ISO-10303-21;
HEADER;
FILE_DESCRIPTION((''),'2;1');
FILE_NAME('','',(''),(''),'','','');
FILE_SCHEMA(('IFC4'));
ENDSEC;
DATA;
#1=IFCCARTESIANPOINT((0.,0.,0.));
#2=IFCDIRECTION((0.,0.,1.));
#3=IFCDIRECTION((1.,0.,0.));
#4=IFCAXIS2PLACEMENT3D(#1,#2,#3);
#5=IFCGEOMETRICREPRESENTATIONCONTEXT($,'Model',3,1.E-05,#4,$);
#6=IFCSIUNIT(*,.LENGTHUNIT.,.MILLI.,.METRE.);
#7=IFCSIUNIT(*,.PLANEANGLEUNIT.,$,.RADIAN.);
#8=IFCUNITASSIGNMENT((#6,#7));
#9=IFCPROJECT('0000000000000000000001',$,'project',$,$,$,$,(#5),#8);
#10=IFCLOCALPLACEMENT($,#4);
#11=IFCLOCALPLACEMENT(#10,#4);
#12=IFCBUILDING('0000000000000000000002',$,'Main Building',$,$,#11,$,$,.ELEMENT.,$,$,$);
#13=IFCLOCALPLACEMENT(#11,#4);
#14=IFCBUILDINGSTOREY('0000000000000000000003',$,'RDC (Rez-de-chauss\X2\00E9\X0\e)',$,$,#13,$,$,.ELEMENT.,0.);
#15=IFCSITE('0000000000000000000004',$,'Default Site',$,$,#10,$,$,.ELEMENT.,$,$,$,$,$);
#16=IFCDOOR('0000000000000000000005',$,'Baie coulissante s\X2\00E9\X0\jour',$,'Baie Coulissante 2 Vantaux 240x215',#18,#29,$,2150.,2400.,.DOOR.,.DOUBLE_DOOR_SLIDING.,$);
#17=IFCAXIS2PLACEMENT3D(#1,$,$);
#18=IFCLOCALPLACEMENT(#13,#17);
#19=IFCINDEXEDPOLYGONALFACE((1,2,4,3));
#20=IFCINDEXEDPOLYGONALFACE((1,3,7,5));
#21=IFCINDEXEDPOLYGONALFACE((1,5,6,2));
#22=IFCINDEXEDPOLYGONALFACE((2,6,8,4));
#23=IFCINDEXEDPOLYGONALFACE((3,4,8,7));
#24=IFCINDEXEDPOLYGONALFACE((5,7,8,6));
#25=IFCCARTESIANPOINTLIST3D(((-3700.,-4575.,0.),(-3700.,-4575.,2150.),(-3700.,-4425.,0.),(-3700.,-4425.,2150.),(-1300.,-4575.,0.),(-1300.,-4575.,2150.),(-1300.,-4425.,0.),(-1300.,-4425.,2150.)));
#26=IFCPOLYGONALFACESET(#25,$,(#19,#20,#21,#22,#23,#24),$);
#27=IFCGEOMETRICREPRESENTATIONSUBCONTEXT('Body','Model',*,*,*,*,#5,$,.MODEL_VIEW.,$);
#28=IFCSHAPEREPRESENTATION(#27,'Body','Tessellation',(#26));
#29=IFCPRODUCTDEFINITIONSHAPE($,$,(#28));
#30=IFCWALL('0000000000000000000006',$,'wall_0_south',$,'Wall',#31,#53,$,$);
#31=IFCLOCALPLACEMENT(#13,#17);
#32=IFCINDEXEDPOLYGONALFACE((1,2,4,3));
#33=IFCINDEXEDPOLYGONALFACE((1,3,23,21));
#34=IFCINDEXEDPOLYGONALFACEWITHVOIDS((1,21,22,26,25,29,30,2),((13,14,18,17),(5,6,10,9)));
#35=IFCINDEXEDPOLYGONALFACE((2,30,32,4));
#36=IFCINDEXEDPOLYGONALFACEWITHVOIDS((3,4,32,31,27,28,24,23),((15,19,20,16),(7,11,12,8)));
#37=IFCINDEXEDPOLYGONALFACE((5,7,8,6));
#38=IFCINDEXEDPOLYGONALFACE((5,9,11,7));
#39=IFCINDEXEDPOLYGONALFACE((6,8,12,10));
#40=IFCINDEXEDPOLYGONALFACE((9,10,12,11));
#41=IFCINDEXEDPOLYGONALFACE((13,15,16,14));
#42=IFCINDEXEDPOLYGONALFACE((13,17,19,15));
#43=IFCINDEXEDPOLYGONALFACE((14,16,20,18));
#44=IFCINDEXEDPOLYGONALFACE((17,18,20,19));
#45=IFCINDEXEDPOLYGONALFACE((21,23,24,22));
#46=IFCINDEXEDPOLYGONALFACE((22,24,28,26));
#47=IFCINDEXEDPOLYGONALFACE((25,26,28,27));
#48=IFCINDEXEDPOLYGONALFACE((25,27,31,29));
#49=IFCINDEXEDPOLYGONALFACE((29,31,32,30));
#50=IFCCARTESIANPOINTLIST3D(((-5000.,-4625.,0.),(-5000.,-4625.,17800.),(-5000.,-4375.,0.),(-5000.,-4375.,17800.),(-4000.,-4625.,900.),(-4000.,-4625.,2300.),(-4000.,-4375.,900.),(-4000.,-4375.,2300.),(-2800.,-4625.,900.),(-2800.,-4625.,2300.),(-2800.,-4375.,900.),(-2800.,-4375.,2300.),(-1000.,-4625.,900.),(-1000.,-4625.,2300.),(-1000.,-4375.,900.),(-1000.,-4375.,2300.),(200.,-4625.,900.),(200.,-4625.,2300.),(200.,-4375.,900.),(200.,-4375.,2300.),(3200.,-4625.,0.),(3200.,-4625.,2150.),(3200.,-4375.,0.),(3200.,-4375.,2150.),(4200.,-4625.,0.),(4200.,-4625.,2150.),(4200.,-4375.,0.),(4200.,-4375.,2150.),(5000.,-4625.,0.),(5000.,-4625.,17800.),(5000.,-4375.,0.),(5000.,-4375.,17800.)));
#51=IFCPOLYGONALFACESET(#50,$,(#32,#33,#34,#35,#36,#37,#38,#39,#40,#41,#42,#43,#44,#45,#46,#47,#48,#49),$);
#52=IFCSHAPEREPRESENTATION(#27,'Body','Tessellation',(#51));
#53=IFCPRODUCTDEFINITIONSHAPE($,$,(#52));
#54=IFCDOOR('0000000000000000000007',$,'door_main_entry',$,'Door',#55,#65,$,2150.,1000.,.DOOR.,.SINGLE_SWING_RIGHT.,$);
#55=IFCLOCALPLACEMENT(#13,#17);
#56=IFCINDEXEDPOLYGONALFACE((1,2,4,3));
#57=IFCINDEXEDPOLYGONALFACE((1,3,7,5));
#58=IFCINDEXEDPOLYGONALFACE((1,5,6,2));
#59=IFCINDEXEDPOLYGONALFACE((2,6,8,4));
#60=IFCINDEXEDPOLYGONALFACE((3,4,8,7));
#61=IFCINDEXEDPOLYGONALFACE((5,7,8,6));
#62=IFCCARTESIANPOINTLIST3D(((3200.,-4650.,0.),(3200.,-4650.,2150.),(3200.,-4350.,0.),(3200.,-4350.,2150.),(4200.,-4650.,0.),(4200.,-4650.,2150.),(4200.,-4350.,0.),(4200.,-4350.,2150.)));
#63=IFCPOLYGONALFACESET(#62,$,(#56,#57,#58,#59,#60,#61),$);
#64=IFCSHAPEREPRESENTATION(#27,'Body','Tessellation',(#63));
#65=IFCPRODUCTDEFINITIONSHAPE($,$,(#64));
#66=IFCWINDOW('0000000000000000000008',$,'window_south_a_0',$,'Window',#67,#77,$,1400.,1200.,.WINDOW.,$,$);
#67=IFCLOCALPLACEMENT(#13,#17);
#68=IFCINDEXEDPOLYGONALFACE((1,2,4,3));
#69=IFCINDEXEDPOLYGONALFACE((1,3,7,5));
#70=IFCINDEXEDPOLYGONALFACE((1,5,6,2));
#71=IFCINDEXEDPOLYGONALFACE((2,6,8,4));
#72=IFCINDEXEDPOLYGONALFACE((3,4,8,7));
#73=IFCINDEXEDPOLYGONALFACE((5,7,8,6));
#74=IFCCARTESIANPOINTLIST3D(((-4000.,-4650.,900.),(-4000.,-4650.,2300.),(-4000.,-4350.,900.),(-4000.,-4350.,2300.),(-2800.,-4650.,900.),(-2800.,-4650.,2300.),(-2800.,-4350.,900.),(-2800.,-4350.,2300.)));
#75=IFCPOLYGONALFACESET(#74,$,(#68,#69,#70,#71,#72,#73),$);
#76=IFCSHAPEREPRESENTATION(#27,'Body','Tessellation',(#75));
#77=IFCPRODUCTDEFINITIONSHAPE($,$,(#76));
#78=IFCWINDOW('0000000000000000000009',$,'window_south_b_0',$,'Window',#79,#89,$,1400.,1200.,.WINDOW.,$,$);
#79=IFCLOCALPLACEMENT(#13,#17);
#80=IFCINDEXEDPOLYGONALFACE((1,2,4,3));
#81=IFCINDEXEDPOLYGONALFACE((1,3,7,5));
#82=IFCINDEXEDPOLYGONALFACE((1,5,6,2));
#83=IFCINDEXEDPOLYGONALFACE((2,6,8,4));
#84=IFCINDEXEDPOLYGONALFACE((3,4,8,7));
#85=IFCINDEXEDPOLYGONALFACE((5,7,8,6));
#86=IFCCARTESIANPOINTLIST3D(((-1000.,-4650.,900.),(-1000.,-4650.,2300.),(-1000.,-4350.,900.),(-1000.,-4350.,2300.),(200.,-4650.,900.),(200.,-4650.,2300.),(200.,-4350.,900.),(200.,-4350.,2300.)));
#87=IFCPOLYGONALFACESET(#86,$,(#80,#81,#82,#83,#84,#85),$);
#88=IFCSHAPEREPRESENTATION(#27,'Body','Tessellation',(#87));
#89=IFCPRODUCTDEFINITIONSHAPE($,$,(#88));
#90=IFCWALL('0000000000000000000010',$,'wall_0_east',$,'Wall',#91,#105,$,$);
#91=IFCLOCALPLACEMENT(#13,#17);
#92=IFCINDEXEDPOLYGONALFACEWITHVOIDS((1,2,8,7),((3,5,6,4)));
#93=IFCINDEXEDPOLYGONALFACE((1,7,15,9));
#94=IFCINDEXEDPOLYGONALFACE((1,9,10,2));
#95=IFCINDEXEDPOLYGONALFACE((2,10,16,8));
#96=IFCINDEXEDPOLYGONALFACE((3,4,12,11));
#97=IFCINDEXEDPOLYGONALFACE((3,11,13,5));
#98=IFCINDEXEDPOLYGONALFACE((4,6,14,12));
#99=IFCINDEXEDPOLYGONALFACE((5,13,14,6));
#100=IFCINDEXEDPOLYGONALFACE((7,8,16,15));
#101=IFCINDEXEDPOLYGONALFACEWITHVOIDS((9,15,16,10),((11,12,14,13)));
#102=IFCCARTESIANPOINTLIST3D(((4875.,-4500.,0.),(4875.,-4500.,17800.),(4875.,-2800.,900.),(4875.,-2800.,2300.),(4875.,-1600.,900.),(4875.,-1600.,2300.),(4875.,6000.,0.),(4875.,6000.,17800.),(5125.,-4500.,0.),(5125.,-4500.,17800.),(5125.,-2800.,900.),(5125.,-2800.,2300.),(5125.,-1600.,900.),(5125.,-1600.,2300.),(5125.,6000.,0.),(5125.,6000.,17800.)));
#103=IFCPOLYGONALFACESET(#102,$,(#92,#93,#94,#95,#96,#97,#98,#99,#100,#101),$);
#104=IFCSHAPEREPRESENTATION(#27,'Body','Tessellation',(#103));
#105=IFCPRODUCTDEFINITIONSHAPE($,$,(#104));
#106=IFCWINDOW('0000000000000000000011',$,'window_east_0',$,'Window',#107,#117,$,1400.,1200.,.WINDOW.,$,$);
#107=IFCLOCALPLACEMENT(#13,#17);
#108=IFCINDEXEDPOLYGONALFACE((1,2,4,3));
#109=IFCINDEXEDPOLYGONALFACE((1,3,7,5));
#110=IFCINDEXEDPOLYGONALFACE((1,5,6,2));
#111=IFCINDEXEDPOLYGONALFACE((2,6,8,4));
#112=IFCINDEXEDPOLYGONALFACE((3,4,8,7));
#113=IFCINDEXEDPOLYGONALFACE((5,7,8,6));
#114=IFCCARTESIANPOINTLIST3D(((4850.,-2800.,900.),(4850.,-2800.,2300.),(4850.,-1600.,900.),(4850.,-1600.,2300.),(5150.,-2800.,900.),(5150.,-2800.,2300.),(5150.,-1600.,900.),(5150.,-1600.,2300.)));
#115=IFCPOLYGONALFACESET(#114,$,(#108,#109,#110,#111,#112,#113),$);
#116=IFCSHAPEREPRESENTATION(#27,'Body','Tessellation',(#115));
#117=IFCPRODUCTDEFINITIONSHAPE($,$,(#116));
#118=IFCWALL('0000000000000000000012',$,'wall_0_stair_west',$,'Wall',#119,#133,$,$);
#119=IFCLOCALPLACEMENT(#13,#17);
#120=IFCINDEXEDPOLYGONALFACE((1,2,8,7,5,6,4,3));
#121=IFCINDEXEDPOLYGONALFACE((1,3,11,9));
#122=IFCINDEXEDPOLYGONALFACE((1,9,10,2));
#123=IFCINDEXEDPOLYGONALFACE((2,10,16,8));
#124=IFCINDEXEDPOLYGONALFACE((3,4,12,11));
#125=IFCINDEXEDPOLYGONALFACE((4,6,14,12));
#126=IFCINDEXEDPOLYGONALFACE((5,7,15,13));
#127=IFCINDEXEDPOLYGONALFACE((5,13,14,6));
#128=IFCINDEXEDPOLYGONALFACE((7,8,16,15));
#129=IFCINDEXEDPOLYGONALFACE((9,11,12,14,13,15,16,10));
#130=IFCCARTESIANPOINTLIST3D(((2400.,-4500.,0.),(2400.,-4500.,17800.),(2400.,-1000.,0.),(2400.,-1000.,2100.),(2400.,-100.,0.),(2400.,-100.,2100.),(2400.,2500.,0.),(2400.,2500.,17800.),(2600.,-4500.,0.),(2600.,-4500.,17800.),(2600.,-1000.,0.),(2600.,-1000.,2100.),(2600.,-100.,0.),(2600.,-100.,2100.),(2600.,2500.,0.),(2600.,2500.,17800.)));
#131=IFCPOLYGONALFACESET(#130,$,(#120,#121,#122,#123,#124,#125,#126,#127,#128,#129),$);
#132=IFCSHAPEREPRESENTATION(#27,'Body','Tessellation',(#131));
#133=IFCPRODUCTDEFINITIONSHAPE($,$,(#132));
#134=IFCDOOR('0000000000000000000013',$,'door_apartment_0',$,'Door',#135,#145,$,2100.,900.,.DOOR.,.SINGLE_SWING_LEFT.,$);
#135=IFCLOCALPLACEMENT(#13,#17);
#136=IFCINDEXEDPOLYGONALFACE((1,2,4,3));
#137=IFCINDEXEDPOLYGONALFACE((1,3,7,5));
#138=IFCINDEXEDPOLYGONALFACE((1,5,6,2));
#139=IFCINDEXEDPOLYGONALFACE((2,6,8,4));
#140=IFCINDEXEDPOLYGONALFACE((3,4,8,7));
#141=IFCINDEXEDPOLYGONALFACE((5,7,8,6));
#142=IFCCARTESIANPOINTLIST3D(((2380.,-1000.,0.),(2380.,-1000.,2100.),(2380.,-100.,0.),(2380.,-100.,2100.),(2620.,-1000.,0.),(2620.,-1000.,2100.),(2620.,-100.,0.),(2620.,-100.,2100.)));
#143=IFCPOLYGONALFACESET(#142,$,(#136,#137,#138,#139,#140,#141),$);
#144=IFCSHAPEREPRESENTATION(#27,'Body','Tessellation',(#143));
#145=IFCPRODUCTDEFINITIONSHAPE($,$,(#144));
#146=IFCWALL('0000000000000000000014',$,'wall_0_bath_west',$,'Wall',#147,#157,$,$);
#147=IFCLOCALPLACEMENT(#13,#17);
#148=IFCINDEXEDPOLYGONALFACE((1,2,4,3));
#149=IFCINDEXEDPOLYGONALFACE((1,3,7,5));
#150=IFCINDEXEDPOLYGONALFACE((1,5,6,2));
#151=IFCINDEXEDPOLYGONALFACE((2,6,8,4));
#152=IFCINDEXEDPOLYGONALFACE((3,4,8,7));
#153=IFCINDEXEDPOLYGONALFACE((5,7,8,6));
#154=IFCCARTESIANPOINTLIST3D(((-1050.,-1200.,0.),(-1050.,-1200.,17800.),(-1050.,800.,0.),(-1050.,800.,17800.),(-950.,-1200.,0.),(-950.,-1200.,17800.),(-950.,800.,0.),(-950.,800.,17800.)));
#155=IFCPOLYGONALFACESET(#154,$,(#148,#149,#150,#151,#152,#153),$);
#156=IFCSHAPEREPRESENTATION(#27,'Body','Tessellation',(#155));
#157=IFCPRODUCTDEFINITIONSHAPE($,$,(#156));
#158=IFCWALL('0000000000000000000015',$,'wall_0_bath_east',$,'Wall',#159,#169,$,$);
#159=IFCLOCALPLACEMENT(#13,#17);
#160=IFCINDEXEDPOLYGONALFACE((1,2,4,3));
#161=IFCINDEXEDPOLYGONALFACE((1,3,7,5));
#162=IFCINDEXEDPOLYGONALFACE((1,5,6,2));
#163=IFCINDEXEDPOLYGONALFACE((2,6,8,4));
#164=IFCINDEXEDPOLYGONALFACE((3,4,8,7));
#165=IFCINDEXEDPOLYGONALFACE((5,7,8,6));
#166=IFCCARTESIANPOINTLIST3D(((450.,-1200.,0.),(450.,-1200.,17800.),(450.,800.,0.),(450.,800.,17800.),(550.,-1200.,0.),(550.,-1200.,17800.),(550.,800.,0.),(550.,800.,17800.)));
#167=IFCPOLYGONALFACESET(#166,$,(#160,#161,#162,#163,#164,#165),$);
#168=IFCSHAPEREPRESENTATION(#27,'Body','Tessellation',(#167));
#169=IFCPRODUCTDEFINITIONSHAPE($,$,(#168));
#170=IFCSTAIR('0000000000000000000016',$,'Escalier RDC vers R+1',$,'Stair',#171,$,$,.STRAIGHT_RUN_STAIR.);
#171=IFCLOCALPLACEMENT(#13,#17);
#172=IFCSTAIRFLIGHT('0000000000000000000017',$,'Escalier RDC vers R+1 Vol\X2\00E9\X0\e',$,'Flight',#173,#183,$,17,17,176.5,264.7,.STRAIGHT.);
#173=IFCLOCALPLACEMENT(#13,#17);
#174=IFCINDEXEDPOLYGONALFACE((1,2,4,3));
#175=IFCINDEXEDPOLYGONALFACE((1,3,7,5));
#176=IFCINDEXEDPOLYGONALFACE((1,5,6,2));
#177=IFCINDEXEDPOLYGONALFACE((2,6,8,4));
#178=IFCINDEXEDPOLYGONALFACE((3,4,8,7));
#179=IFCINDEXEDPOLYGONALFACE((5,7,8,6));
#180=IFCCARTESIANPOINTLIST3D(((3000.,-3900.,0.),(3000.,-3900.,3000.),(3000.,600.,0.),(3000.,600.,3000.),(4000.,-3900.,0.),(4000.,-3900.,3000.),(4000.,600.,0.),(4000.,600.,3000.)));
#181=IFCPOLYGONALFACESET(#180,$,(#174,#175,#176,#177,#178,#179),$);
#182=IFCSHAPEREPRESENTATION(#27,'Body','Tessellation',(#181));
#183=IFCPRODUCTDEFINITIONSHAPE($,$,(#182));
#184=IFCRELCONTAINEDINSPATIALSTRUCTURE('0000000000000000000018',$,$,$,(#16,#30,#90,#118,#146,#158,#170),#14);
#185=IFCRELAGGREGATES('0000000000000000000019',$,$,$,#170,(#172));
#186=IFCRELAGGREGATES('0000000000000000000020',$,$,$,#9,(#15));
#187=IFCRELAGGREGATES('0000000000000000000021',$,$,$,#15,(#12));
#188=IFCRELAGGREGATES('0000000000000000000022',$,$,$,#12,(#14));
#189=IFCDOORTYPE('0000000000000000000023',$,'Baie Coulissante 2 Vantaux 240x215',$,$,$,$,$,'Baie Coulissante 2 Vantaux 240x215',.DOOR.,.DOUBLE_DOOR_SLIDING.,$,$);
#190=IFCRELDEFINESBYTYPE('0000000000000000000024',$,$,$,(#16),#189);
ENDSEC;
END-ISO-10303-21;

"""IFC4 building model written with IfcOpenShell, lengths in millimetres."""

from ifc_helpers import new_model, si_unit, frame, origin_with_axes, place, context, subcontext, project, spatial, polyline, outline, extrude, type_object, element, fill, aggregate, save


model = new_model("IFC4")

# Units and contexts
model_context = context("Model", 3, precision=1e-05, world=origin_with_axes())
body_context = subcontext(model_context, "Body", "Model", "MODEL_VIEW")
ifc_project = project(units=[si_unit("LENGTHUNIT", "METRE", prefix="MILLI"), si_unit("PLANEANGLEUNIT", "RADIAN")], contexts=[model_context])

# Site, building, storey
site_placement = place(None, origin_with_axes())
site = spatial("IfcSite", under=ifc_project, at=site_placement, Name="Default Site", CompositionType="ELEMENT")
building_placement = place(site_placement, origin_with_axes())
building = spatial("IfcBuilding", under=site, at=building_placement, Name="Main Building", CompositionType="ELEMENT")
storey_placement = place(building_placement, origin_with_axes())
storey = spatial("IfcBuildingStorey", under=building, at=storey_placement, Name="RDC (Rez-de-chaussée)", CompositionType="ELEMENT", Elevation=0.0)

# Door
door_type = type_object("IfcDoorType", Name="Baie Coulissante 2 Vantaux 240x215", ElementType="Baie Coulissante 2 Vantaux 240x215", OperationType="DOUBLE_DOOR_SLIDING", PredefinedType="DOOR")
door_1_placement = place(storey_placement, frame((-2500.0, -4500.0, 0.0), z_axis=(0.0, 0.0, 1.0), x_axis=(1.0, 0.0, 0.0)))
element("IfcDoor", 1, at=door_1_placement, inside=storey, type_object=door_type, Name="Baie coulissante séjour", ObjectType="Baie Coulissante 2 Vantaux 240x215", OperationType="DOUBLE_DOOR_SLIDING", OverallHeight=2150.0, OverallWidth=2400.0, PredefinedType="DOOR", context=body_context, shape_type="SweptSolid", body=[
    extrude(outline(polyline([(-1200.0, -75.0), (1200.0, -75.0), (1200.0, 75.0), (-1200.0, 75.0), (-1200.0, -75.0)])), origin_with_axes(), (0.0, 0.0, 1.0), 2150.0),
])

# Wall, openings, door, windows
wall_1_placement = place(storey_placement, frame((-5000.0, -4500.0, 0.0), z_axis=(0.0, 0.0, 1.0), x_axis=(1.0, 0.0, 0.0)))
wall_1 = element("IfcWall", 2, at=wall_1_placement, inside=storey, Name="wall_0_south", ObjectType="Wall", context=body_context, shape_type="SweptSolid", body=[
    extrude(outline(polyline([(0.0, -125.0), (10000.0, -125.0), (10000.0, 125.0), (0.0, 125.0), (0.0, -125.0)])), origin_with_axes(), (0.0, 0.0, 1.0), 17800.0),
])
placement_1 = place(wall_1_placement, frame((8200.0, 0.0, 0.0), z_axis=(0.0, 0.0, 1.0), x_axis=(1.0, 0.0, 0.0)))
opening_1 = element("IfcOpeningElement", 3, at=placement_1, cuts=wall_1, PredefinedType="OPENING", context=body_context, shape_type="SweptSolid", body=[
    extrude(outline(polyline([(0.0, -150.0), (1000.0, -150.0), (1000.0, 150.0), (0.0, 150.0), (0.0, -150.0)])), origin_with_axes(), (0.0, 0.0, 1.0), 2150.0),
])
placement_2 = place(wall_1_placement, frame((1000.0, 0.0, 900.0), z_axis=(0.0, 0.0, 1.0), x_axis=(1.0, 0.0, 0.0)))
opening_2 = element("IfcOpeningElement", 4, at=placement_2, cuts=wall_1, PredefinedType="OPENING", context=body_context, shape_type="SweptSolid", body=[
    extrude(outline(polyline([(0.0, -150.0), (1200.0, -150.0), (1200.0, 150.0), (0.0, 150.0), (0.0, -150.0)])), origin_with_axes(), (0.0, 0.0, 1.0), 1400.0),
])
placement_3 = place(wall_1_placement, frame((4000.0, 0.0, 900.0), z_axis=(0.0, 0.0, 1.0), x_axis=(1.0, 0.0, 0.0)))
opening_3 = element("IfcOpeningElement", 5, at=placement_3, cuts=wall_1, PredefinedType="OPENING", context=body_context, shape_type="SweptSolid", body=[
    extrude(outline(polyline([(0.0, -150.0), (1200.0, -150.0), (1200.0, 150.0), (0.0, 150.0), (0.0, -150.0)])), origin_with_axes(), (0.0, 0.0, 1.0), 1400.0),
])
door_2 = element("IfcDoor", 6, at=placement_1, Name="door_main_entry", ObjectType="Door", OperationType="SINGLE_SWING_RIGHT", OverallHeight=2150.0, OverallWidth=1000.0, PredefinedType="DOOR", context=body_context, shape_type="SweptSolid", body=[
    extrude(outline(polyline([(0.0, -150.0), (1000.0, -150.0), (1000.0, 150.0), (0.0, 150.0), (0.0, -150.0)])), origin_with_axes(), (0.0, 0.0, 1.0), 2150.0),
])
fill(opening_1, door_2)
window_1 = element("IfcWindow", 7, at=placement_2, Name="window_south_a_0", ObjectType="Window", OverallHeight=1400.0, OverallWidth=1200.0, PredefinedType="WINDOW", context=body_context, shape_type="SweptSolid", body=[
    extrude(outline(polyline([(0.0, -150.0), (1200.0, -150.0), (1200.0, 150.0), (0.0, 150.0), (0.0, -150.0)])), origin_with_axes(), (0.0, 0.0, 1.0), 1400.0),
])
fill(opening_2, window_1)
window_2 = element("IfcWindow", 8, at=placement_3, Name="window_south_b_0", ObjectType="Window", OverallHeight=1400.0, OverallWidth=1200.0, PredefinedType="WINDOW", context=body_context, shape_type="SweptSolid", body=[
    extrude(outline(polyline([(0.0, -150.0), (1200.0, -150.0), (1200.0, 150.0), (0.0, 150.0), (0.0, -150.0)])), origin_with_axes(), (0.0, 0.0, 1.0), 1400.0),
])
fill(opening_3, window_2)

# Wall, opening, window
wall_2_placement = place(storey_placement, frame((5000.0, -4500.0, 0.0), z_axis=(0.0, 0.0, 1.0), x_axis=(0.0, 1.0, 0.0)))
wall_2 = element("IfcWall", 9, at=wall_2_placement, inside=storey, Name="wall_0_east", ObjectType="Wall", context=body_context, shape_type="SweptSolid", body=[
    extrude(outline(polyline([(0.0, -125.0), (10500.0, -125.0), (10500.0, 125.0), (0.0, 125.0), (0.0, -125.0)])), origin_with_axes(), (0.0, 0.0, 1.0), 17800.0),
])
placement_4 = place(wall_2_placement, frame((1700.0, 0.0, 900.0), z_axis=(0.0, 0.0, 1.0), x_axis=(1.0, 0.0, 0.0)))
opening_4 = element("IfcOpeningElement", 10, at=placement_4, cuts=wall_2, PredefinedType="OPENING", context=body_context, shape_type="SweptSolid", body=[
    extrude(outline(polyline([(0.0, -150.0), (1200.0, -150.0), (1200.0, 150.0), (0.0, 150.0), (0.0, -150.0)])), origin_with_axes(), (0.0, 0.0, 1.0), 1400.0),
])
window_3 = element("IfcWindow", 11, at=placement_4, Name="window_east_0", ObjectType="Window", OverallHeight=1400.0, OverallWidth=1200.0, PredefinedType="WINDOW", context=body_context, shape_type="SweptSolid", body=[
    extrude(outline(polyline([(0.0, -150.0), (1200.0, -150.0), (1200.0, 150.0), (0.0, 150.0), (0.0, -150.0)])), origin_with_axes(), (0.0, 0.0, 1.0), 1400.0),
])
fill(opening_4, window_3)

# Wall, opening, door
wall_3_placement = place(storey_placement, frame((2500.0, -4500.0, 0.0), z_axis=(0.0, 0.0, 1.0), x_axis=(0.0, 1.0, 0.0)))
wall_3 = element("IfcWall", 12, at=wall_3_placement, inside=storey, Name="wall_0_stair_west", ObjectType="Wall", context=body_context, shape_type="SweptSolid", body=[
    extrude(outline(polyline([(0.0, -100.0), (7000.0, -100.0), (7000.0, 100.0), (0.0, 100.0), (0.0, -100.0)])), origin_with_axes(), (0.0, 0.0, 1.0), 17800.0),
])
placement_5 = place(wall_3_placement, frame((3500.0, 0.0, 0.0), z_axis=(0.0, 0.0, 1.0), x_axis=(1.0, 0.0, 0.0)))
opening_5 = element("IfcOpeningElement", 13, at=placement_5, cuts=wall_3, PredefinedType="OPENING", context=body_context, shape_type="SweptSolid", body=[
    extrude(outline(polyline([(0.0, -120.0), (900.0, -120.0), (900.0, 120.0), (0.0, 120.0), (0.0, -120.0)])), origin_with_axes(), (0.0, 0.0, 1.0), 2100.0),
])
door_3 = element("IfcDoor", 14, at=placement_5, Name="door_apartment_0", ObjectType="Door", OperationType="SINGLE_SWING_LEFT", OverallHeight=2100.0, OverallWidth=900.0, PredefinedType="DOOR", context=body_context, shape_type="SweptSolid", body=[
    extrude(outline(polyline([(0.0, -120.0), (900.0, -120.0), (900.0, 120.0), (0.0, 120.0), (0.0, -120.0)])), origin_with_axes(), (0.0, 0.0, 1.0), 2100.0),
])
fill(opening_5, door_3)

# Walls
for number, where, z_axis, x_axis, name in (
    (15, (-1000.0, -1200.0, 0.0), (0.0, 0.0, 1.0), (0.0, 1.0, 0.0), "wall_0_bath_west"),
    (16, (500.0, -1200.0, 0.0), (0.0, 0.0, 1.0), (0.0, 1.0, 0.0), "wall_0_bath_east"),
):
    element("IfcWall", number, at=place(storey_placement, frame(where, z_axis=z_axis, x_axis=x_axis)), inside=storey, Name=name, ObjectType="Wall", context=body_context, shape_type="SweptSolid", body=[
        extrude(outline(polyline([(0.0, -50.0), (2000.0, -50.0), (2000.0, 50.0), (0.0, 50.0), (0.0, -50.0)])), origin_with_axes(), (0.0, 0.0, 1.0), 17800.0),
    ])

# Stair, stair flight
stair_placement = place(storey_placement, frame((3500.0, -3900.0, 0.0), z_axis=(0.0, 0.0, 1.0), x_axis=(0.0, 1.0, 0.0)))
stair = element("IfcStair", 17, at=stair_placement, inside=storey, Name="Escalier RDC vers R+1", ObjectType="Stair", PredefinedType="STRAIGHT_RUN_STAIR")
stair_flight_placement = place(stair_placement, origin_with_axes())
stair_flight = element("IfcStairFlight", 18, at=stair_flight_placement, Name="Escalier RDC vers R+1 Volée", ObjectType="Flight", NumberOfRisers=17, NumberOfTreads=17, PredefinedType="STRAIGHT", RiserHeight=176.5, TreadLength=264.7, context=body_context, shape_type="SweptSolid", body=[
    extrude(outline(polyline([(0.0, -500.0), (4500.0, -500.0), (4500.0, 500.0), (0.0, 500.0), (0.0, -500.0)])), origin_with_axes(), (0.0, 0.0, 1.0), 3000.0),
])
aggregate(stair, [stair_flight])

save(model, "model.ifc")
